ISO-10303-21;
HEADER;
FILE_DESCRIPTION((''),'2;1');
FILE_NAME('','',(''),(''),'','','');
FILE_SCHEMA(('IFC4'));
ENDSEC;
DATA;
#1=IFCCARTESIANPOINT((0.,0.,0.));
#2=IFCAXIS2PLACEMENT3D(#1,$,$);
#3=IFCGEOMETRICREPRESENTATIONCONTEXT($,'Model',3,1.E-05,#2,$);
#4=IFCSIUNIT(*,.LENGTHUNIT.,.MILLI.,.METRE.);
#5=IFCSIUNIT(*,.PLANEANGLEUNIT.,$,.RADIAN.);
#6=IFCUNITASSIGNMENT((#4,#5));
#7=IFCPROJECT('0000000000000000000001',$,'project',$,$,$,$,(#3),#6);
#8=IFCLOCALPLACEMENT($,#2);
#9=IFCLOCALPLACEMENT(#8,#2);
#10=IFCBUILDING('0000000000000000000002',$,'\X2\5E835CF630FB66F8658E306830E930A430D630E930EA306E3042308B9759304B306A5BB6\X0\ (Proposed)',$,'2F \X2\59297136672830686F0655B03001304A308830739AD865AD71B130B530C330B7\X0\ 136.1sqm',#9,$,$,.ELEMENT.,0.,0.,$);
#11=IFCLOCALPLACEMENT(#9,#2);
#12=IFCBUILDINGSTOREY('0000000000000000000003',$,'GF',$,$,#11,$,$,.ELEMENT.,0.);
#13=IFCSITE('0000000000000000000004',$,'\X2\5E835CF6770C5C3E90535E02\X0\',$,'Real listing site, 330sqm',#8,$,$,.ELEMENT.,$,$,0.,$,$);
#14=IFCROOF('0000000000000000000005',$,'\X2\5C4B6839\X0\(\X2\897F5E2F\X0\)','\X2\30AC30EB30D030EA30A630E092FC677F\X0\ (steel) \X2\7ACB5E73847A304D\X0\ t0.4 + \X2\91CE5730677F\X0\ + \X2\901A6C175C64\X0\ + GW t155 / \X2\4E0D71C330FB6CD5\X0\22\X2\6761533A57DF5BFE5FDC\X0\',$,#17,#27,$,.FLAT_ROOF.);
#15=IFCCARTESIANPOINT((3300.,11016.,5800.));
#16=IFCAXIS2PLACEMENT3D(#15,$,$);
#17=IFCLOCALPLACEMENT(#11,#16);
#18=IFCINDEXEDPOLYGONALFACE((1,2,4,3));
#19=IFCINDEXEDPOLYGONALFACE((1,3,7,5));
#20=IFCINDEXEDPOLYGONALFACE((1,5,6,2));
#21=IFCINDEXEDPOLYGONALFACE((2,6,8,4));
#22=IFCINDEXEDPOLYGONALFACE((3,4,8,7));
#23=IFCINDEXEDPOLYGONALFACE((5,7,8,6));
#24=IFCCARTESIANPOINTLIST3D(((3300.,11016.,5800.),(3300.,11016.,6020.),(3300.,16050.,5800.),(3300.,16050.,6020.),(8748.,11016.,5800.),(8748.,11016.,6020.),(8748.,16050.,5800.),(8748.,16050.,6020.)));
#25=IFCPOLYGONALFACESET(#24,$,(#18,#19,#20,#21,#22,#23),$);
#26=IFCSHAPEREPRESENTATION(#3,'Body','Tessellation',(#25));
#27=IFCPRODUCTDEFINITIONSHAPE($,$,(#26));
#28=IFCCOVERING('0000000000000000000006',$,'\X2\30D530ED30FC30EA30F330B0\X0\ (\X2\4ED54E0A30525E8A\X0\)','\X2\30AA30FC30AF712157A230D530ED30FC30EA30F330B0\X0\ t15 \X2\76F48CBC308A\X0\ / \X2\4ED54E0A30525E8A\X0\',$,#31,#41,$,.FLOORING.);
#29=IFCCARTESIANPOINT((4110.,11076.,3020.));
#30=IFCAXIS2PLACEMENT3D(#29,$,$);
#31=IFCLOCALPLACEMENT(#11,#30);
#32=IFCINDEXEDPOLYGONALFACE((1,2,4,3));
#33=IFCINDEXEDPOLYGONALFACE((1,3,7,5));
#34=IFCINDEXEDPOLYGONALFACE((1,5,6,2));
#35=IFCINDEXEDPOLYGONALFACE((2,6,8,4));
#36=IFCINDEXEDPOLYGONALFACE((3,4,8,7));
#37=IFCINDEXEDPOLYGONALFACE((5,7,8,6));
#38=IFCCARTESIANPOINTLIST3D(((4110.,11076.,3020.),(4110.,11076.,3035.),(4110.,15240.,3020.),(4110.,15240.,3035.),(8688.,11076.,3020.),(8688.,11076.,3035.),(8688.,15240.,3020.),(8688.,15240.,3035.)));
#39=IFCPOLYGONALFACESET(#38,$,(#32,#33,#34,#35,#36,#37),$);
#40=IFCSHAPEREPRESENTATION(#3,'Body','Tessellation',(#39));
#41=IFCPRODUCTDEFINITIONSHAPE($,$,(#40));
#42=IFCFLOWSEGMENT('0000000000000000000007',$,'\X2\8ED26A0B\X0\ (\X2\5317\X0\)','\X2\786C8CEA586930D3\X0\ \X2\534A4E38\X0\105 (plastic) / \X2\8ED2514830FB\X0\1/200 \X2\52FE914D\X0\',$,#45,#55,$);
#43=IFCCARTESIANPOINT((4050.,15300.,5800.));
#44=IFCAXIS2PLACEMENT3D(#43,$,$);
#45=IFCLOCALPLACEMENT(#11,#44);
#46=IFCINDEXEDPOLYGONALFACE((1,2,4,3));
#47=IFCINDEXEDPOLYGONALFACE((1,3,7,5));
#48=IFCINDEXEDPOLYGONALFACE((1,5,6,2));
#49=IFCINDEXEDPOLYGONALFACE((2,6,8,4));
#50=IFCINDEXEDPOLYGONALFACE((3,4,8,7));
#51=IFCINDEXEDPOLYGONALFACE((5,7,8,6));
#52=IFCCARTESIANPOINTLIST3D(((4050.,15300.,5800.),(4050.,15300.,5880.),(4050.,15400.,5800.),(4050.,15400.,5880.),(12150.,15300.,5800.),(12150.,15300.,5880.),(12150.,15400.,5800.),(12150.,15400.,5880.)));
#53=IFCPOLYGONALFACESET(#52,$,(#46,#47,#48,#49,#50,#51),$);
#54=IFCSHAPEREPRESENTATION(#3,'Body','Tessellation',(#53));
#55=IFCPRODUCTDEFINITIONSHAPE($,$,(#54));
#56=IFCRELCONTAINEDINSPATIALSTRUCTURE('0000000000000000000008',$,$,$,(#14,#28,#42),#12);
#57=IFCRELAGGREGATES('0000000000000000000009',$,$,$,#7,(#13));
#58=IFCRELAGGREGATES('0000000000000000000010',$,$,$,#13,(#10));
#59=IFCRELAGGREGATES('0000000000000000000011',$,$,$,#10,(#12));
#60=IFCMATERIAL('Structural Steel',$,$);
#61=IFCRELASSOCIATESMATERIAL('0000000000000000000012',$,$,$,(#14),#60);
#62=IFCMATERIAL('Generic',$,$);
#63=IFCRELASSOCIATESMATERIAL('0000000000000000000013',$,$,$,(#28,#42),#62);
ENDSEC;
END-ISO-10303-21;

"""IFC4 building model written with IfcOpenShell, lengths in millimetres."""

from ifc_helpers import new_model, si_unit, frame, frame_2d, origin, place, context, project, spatial, rectangle, extrude, material, element, save


model = new_model("IFC4")

# Units and contexts
model_context = context("Model", 3, precision=1e-05, world=origin())
ifc_project = project(units=[si_unit("LENGTHUNIT", "METRE", prefix="MILLI"), si_unit("PLANEANGLEUNIT", "RADIAN")], contexts=[model_context])

# Site, building, storey
site_placement = place(None, origin())
site = spatial("IfcSite", under=ifc_project, at=site_placement, Name="広島県尾道市", ObjectType="Real listing site, 330sqm", CompositionType="ELEMENT", RefElevation=0.0)
building_placement = place(site_placement, origin())
building = spatial("IfcBuilding", under=site, at=building_placement, Name="広島・書斎とライブラリのある静かな家 (Proposed)", ObjectType="2F 天然木と漆喰、および高断熱サッシ 136.1sqm", CompositionType="ELEMENT", ElevationOfRefHeight=0.0, ElevationOfTerrain=0.0)
storey_placement = place(building_placement, origin())
storey = spatial("IfcBuildingStorey", under=building, at=storey_placement, Name="GF", CompositionType="ELEMENT", Elevation=0.0)

# Roof
ifc_material_1 = material(Name="Structural Steel")
for number, where, name in (
    (1, (3300.0, 11016.0, 5800.0), "屋根(西帯)"),
):
    element("IfcRoof", number, at=place(storey_placement, frame(where)), inside=storey, material=ifc_material_1, Name=name, Description="ガルバリウム鋼板 (steel) 立平葺き t0.4 + 野地板 + 通気層 + GW t155 / 不燃・法22条区域対応", PredefinedType="FLAT_ROOF", context=model_context, shape_type="SweptSolid", body=[
        extrude(rectangle(XDim=5448.0, YDim=5034.0, at=frame_2d((2724.0, 2517.0))), frame((3300.0, 11016.0, 5800.0)), (0.0, 0.0, 1.0), 220.0),
    ])

# Covering
ifc_material_2 = material(Name="Generic")
covering_placement = place(storey_placement, frame((4110.0, 11076.0, 3020.0)))
element("IfcCovering", 2, at=covering_placement, inside=storey, material=ifc_material_2, Name="フローリング (仕上げ床)", Description="オーク無垢フローリング t15 直貼り / 仕上げ床", PredefinedType="FLOORING", context=model_context, shape_type="SweptSolid", body=[
    extrude(rectangle(XDim=4578.0, YDim=4164.0, at=frame_2d((2289.0, 2082.0))), frame((4110.0, 11076.0, 3020.0)), (0.0, 0.0, 1.0), 15.0),
])

# Flow segment
flow_segment_placement = place(storey_placement, frame((4050.0, 15300.0, 5800.0)))
element("IfcFlowSegment", 3, at=flow_segment_placement, inside=storey, material=ifc_material_2, Name="軒樋 (北)", Description="硬質塩ビ 半丸105 (plastic) / 軒先・1/200 勾配", context=model_context, shape_type="SweptSolid", body=[
    extrude(rectangle(XDim=8100.0, YDim=100.0, at=frame_2d((4050.0, 50.0))), frame((4050.0, 15300.0, 5800.0)), (0.0, 0.0, 1.0), 80.0),
])

save(model, "model.ifc")
